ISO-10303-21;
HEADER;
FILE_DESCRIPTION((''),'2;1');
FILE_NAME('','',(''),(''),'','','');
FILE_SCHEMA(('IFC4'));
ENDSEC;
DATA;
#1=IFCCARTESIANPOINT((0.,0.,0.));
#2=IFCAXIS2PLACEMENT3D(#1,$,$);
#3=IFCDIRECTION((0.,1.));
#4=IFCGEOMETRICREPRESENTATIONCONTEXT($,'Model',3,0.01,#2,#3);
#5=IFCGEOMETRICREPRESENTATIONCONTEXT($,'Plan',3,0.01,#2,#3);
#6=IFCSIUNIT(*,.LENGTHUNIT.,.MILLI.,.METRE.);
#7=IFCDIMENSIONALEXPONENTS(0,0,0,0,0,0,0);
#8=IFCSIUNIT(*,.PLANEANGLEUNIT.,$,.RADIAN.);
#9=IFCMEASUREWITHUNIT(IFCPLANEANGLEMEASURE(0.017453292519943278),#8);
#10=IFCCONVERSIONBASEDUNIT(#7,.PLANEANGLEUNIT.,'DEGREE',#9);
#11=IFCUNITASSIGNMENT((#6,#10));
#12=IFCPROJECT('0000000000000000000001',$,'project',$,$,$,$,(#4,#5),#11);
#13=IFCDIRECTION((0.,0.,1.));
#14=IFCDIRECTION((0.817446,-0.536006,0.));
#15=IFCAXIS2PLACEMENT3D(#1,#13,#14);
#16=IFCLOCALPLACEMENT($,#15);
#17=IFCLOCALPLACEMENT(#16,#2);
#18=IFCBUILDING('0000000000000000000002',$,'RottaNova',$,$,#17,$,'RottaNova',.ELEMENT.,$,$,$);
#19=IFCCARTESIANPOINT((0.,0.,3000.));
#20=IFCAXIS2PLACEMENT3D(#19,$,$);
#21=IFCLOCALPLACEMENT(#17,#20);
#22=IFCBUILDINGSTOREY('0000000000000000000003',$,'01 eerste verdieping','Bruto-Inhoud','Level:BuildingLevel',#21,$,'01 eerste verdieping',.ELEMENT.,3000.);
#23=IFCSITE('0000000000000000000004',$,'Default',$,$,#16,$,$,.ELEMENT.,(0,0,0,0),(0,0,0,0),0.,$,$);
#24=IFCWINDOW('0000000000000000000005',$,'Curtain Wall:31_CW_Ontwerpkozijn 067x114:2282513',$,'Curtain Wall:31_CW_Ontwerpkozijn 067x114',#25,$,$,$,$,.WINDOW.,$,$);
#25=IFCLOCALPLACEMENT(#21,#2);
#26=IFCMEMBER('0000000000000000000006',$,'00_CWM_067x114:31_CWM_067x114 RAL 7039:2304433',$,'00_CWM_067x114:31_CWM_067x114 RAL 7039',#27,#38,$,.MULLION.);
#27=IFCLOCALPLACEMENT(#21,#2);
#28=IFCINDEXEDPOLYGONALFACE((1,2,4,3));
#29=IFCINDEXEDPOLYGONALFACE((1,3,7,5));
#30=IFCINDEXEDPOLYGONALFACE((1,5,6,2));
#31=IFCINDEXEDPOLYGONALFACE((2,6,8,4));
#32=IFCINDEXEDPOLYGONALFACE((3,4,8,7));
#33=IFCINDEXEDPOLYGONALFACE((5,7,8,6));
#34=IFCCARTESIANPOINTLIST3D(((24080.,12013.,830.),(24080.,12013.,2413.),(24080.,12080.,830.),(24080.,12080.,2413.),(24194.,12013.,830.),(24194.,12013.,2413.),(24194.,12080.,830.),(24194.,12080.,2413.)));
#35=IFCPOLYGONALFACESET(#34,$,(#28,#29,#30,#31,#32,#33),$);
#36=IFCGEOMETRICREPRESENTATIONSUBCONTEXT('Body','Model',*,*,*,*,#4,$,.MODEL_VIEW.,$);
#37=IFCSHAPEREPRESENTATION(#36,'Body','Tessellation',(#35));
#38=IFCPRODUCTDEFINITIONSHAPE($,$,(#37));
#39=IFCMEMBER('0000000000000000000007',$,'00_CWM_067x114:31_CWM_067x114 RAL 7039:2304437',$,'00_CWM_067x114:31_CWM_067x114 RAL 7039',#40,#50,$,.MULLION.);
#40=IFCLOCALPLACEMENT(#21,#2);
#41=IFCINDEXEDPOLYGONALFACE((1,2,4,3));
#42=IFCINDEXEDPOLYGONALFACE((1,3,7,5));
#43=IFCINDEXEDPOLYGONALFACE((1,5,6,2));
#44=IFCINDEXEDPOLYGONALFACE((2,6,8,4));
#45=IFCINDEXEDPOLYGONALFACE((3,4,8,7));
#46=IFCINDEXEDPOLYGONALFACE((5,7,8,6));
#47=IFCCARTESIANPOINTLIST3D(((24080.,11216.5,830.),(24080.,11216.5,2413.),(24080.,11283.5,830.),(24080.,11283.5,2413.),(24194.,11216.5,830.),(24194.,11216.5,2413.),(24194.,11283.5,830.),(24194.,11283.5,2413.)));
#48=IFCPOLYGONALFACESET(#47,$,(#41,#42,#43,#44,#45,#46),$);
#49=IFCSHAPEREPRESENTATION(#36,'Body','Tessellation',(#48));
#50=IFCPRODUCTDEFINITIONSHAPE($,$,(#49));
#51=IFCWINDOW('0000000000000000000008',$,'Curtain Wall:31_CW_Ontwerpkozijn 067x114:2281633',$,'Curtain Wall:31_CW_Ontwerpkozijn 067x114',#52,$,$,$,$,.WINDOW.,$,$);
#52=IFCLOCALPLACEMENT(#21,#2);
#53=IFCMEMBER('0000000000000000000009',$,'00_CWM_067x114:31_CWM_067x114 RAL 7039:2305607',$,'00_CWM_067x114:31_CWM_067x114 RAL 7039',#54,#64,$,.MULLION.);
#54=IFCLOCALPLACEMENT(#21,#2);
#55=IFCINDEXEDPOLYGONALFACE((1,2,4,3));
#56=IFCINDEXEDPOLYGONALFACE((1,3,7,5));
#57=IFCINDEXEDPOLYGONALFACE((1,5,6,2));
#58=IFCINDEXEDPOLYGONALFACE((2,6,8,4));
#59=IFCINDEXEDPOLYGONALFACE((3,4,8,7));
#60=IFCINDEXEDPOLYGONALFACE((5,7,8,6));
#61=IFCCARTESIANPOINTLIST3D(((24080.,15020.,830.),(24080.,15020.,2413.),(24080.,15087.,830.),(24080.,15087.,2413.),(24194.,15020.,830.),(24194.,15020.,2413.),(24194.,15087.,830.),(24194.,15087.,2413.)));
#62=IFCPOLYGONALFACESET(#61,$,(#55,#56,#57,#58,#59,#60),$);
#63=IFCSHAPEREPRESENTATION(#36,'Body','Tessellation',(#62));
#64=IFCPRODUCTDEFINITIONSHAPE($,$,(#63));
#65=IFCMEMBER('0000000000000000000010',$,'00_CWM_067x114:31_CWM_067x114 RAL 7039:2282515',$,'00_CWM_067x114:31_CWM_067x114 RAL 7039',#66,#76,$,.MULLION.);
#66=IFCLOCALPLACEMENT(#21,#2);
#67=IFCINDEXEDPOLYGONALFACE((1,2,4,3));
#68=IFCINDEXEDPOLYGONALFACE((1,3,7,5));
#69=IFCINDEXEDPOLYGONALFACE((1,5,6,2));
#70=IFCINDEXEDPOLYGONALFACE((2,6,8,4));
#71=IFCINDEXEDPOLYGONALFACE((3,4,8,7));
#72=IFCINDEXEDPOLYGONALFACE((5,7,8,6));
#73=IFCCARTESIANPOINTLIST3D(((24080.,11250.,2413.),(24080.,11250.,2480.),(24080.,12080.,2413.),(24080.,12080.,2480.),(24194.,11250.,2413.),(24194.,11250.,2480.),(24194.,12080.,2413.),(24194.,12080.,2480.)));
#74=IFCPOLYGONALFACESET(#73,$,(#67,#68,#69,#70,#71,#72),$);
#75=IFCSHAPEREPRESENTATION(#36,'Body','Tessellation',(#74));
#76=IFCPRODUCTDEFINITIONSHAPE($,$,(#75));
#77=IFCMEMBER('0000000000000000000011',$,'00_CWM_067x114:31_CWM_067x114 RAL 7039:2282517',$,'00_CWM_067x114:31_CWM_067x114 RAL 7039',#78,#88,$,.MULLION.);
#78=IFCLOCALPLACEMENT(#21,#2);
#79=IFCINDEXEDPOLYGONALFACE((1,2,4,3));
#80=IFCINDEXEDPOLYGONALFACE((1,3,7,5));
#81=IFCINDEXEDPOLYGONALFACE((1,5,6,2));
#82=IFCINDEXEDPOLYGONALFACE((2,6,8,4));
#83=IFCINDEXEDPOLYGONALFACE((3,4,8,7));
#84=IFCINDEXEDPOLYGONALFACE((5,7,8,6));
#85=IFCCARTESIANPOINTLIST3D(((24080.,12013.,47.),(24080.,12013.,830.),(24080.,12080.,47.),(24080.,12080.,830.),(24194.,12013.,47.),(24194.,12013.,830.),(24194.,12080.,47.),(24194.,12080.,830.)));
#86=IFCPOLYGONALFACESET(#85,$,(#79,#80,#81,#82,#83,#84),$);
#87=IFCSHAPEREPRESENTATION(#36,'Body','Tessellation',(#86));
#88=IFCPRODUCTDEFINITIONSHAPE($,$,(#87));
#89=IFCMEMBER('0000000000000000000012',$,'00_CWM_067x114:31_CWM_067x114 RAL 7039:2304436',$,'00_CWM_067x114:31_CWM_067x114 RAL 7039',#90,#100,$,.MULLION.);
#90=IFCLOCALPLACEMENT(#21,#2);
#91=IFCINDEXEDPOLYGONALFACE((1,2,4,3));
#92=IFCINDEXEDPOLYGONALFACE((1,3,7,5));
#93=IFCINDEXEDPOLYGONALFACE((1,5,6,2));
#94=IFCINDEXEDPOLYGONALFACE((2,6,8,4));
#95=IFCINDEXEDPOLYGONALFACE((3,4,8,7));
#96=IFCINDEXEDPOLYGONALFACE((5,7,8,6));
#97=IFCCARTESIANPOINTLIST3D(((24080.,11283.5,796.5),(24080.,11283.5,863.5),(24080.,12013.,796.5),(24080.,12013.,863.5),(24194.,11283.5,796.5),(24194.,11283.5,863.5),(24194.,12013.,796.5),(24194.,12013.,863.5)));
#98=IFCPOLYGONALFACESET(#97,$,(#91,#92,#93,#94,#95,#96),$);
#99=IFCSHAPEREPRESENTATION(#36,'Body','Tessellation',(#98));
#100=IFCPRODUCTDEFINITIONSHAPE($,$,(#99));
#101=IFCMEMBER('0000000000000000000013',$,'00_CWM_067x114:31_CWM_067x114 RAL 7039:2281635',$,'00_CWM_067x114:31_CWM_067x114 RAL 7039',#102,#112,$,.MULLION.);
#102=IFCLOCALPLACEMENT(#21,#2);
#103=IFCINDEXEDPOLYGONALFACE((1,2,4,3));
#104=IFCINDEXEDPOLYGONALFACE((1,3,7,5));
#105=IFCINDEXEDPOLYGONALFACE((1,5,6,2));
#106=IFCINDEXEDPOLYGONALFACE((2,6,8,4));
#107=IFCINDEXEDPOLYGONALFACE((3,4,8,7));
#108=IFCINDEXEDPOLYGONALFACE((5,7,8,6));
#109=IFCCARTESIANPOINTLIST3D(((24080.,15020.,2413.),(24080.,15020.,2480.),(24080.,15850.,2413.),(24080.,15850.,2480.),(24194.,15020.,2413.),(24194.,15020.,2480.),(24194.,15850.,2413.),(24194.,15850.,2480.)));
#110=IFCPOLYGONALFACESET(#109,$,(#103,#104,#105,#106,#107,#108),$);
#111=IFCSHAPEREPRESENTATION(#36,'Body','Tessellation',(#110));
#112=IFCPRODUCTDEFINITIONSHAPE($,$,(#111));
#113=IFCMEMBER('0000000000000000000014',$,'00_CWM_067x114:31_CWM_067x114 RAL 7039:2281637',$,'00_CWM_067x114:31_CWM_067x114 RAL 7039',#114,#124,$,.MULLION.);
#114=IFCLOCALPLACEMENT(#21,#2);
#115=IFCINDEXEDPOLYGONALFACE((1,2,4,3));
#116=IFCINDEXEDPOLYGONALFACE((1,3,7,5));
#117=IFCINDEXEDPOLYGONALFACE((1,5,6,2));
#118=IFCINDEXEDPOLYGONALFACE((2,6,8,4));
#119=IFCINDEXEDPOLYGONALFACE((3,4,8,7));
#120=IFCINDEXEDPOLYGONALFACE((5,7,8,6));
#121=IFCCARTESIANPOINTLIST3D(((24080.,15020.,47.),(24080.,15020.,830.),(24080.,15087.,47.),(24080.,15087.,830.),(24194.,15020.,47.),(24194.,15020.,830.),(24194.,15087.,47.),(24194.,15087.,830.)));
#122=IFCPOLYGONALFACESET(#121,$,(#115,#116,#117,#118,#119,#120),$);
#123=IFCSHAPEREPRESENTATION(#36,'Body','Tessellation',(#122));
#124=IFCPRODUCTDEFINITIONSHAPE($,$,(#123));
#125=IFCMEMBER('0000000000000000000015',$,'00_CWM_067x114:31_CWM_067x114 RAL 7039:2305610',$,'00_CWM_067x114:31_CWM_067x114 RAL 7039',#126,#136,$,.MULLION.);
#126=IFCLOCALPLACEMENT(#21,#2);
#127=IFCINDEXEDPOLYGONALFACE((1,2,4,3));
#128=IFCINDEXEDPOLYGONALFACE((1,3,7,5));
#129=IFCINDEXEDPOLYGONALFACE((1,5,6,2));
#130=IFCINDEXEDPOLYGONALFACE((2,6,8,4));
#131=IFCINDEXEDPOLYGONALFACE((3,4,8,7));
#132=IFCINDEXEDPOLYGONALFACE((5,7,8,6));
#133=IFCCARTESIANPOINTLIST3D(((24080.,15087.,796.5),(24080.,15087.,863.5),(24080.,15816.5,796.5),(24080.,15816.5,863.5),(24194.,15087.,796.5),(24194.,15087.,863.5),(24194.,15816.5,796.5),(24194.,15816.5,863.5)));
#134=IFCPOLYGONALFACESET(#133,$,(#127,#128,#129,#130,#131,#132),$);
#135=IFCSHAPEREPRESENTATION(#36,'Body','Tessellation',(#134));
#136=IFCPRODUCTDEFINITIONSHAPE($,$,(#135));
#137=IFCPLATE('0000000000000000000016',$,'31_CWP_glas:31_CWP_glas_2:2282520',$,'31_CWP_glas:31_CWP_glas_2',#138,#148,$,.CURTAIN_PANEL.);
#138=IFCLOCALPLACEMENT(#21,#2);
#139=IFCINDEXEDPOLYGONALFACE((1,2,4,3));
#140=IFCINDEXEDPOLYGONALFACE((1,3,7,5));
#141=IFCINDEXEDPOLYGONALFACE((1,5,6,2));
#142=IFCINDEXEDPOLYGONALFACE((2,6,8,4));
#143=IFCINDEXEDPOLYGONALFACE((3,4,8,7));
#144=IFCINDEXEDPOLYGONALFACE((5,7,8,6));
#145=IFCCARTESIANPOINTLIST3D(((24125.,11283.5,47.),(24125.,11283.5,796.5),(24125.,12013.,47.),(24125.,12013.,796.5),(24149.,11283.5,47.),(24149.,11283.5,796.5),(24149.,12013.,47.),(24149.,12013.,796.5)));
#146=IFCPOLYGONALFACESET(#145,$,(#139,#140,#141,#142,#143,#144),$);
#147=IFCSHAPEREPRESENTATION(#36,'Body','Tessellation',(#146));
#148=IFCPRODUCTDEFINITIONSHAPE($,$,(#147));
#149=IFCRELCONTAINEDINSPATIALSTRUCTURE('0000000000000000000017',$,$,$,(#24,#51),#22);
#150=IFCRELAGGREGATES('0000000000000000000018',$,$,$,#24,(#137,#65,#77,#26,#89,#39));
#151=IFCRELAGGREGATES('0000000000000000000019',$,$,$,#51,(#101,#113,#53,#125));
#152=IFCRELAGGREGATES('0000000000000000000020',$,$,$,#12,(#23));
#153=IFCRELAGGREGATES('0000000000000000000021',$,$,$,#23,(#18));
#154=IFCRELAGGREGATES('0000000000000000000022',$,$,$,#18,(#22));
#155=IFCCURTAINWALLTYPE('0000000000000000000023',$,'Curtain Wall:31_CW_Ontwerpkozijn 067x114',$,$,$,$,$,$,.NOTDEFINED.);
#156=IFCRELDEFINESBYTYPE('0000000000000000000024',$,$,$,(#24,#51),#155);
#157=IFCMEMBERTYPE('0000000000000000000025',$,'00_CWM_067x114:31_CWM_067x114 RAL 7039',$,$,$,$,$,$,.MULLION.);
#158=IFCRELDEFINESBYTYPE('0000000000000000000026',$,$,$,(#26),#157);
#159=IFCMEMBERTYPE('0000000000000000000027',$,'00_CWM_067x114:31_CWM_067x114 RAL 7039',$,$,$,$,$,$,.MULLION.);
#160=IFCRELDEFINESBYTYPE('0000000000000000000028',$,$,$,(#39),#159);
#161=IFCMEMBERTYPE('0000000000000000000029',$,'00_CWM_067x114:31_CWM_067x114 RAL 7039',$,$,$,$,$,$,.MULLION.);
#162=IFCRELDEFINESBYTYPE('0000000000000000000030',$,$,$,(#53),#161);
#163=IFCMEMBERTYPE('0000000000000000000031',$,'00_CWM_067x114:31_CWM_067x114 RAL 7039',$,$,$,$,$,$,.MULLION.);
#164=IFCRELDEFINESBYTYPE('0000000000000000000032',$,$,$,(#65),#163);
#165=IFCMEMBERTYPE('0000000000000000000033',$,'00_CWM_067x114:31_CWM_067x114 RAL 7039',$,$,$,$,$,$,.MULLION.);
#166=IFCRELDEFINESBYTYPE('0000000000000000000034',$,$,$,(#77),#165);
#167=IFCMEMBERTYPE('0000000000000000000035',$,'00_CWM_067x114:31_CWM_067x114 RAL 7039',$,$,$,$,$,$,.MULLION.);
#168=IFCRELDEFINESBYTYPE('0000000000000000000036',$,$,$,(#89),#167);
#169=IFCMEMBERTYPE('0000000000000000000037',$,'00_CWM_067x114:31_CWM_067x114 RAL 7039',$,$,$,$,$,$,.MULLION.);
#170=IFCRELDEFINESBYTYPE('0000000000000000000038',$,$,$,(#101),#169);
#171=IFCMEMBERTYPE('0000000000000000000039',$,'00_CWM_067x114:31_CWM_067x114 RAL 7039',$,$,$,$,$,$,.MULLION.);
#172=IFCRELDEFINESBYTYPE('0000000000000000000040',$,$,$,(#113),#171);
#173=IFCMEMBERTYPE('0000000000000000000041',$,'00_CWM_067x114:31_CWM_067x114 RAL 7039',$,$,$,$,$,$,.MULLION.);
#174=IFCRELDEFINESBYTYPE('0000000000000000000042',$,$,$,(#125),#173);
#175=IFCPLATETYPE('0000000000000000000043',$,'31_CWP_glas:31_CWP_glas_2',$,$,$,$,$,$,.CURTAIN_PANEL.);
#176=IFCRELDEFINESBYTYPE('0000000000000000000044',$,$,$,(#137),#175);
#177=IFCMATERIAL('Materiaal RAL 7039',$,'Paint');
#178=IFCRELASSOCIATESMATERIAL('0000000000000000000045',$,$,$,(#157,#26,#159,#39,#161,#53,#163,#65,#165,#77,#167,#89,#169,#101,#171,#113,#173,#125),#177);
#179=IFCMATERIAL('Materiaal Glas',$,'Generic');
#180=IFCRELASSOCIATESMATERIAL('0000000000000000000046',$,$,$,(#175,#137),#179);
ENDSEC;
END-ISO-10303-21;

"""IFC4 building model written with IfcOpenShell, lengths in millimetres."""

from ifc_helpers import new_model, entity, si_unit, converted_unit, direction, frame, origin, place, context, subcontext, project, spatial, indexed_curve, outline, extrude, source, transform, mapped, material, type_object, type_shapes, element, aggregate, save


model = new_model("IFC4")

# Units and contexts
model_context = context("Model", 3, precision=0.01, world=origin(), true_north=direction((0.0, 1.0)))
plan_context = context("Plan", 3, precision=0.01, world=origin(), true_north=direction((0.0, 1.0)))
body_context = subcontext(model_context, "Body", "Model", "MODEL_VIEW")
ifc_project = project(units=[si_unit("LENGTHUNIT", "METRE", prefix="MILLI"), converted_unit("PLANEANGLEUNIT", "DEGREE", entity("IfcPlaneAngleMeasure", 0.017453292519943278), si_unit("PLANEANGLEUNIT", "RADIAN"), dimensions=[0, 0, 0, 0, 0, 0, 0])], contexts=[model_context, plan_context])

# Site, building, storey
site_placement = place(None, frame((0.0, 0.0, 0.0), z_axis=(0.0, 0.0, 1.0), x_axis=(0.817446, -0.536006, 0.0)))
site = spatial("IfcSite", under=ifc_project, at=site_placement, Name="Default", CompositionType="ELEMENT", RefLatitude=(0, 0, 0, 0), RefLongitude=(0, 0, 0, 0), RefElevation=0.0)
building_placement = place(site_placement, origin())
building = spatial("IfcBuilding", under=site, at=building_placement, Name="RottaNova", LongName="RottaNova", CompositionType="ELEMENT")
storey_placement = place(building_placement, frame((0.0, 0.0, 3000.0)))
storey = spatial("IfcBuildingStorey", under=building, at=storey_placement, Name="01 eerste verdieping", Description="Bruto-Inhoud", ObjectType="Level:BuildingLevel", LongName="01 eerste verdieping", CompositionType="ELEMENT", Elevation=3000.0)

# Window, members
curtain_wall_type = type_object("IfcCurtainWallType", Name="Curtain Wall:31_CW_Ontwerpkozijn 067x114", PredefinedType="NOTDEFINED")
window_1_placement = place(storey_placement, frame((0.0, 0.0, -3000.0)))
window_1 = element("IfcWindow", 1, at=window_1_placement, inside=storey, type_object=curtain_wall_type, Name="Curtain Wall:31_CW_Ontwerpkozijn 067x114:2282513", ObjectType="Curtain Wall:31_CW_Ontwerpkozijn 067x114", PredefinedType="WINDOW")
ifc_material_1 = material(Name="Materiaal RAL 7039", Category="Paint")
member_type_1 = type_object("IfcMemberType", Name="00_CWM_067x114:31_CWM_067x114 RAL 7039", PredefinedType="MULLION", material=ifc_material_1)
shared_shape_1 = source(origin(), body_context, "Body", "SweptSolid", [
    extrude(outline(indexed_curve([(-33.5, -57.0), (33.5, -57.0), (33.5, 57.0), (-33.5, 57.0), (-33.5, -57.0)], self_intersect=False)), frame((-33.5, 57.0, -1583.0), z_axis=(0.0, 0.0, 1.0), x_axis=(-1.0, 0.0, 0.0)), (0.0, 0.0, 1.0), 1583.0),
])
type_shapes(member_type_1, [shared_shape_1])
member_1_placement = place(window_1_placement, frame((24080.0, 12080.0, 3830.0), z_axis=(0.0, 0.0, -1.0), x_axis=(0.0, 1.0, 0.0)))
member_1 = element("IfcMember", 2, at=member_1_placement, type_object=member_type_1, material=ifc_material_1, Name="00_CWM_067x114:31_CWM_067x114 RAL 7039:2304433", ObjectType="00_CWM_067x114:31_CWM_067x114 RAL 7039", PredefinedType="MULLION", context=body_context, shape_type="MappedRepresentation", body=[
    mapped(shared_shape_1, transform((0.0, 0.0, 0.0), scale=1.0)),
])
member_type_2 = type_object("IfcMemberType", Name="00_CWM_067x114:31_CWM_067x114 RAL 7039", PredefinedType="MULLION", material=ifc_material_1)
shared_shape_2 = source(origin(), body_context, "Body", "SweptSolid", [
    extrude(outline(indexed_curve([(-33.5, -57.0), (33.5, -57.0), (33.5, 57.0), (-33.5, 57.0), (-33.5, -57.0)], self_intersect=False)), frame((0.0, 57.0, -1583.0), z_axis=(0.0, 0.0, 1.0), x_axis=(-1.0, 0.0, 0.0)), (0.0, 0.0, 1.0), 1583.0),
])
type_shapes(member_type_2, [shared_shape_2])
member_2_placement = place(window_1_placement, frame((24080.0, 11250.0, 3830.0), z_axis=(0.0, 0.0, -1.0), x_axis=(0.0, 1.0, 0.0)))
member_2 = element("IfcMember", 3, at=member_2_placement, type_object=member_type_2, material=ifc_material_1, Name="00_CWM_067x114:31_CWM_067x114 RAL 7039:2304437", ObjectType="00_CWM_067x114:31_CWM_067x114 RAL 7039", PredefinedType="MULLION", context=body_context, shape_type="MappedRepresentation", body=[
    mapped(shared_shape_2, transform((0.0, 0.0, 0.0), scale=1.0)),
])

# Window, member
window_2_placement = place(storey_placement, frame((0.0, 0.0, -3000.0)))
window_2 = element("IfcWindow", 4, at=window_2_placement, inside=storey, type_object=curtain_wall_type, Name="Curtain Wall:31_CW_Ontwerpkozijn 067x114:2281633", ObjectType="Curtain Wall:31_CW_Ontwerpkozijn 067x114", PredefinedType="WINDOW")
member_type_3 = type_object("IfcMemberType", Name="00_CWM_067x114:31_CWM_067x114 RAL 7039", PredefinedType="MULLION", material=ifc_material_1)
shared_shape_3 = source(origin(), body_context, "Body", "SweptSolid", [
    extrude(outline(indexed_curve([(-33.5, -57.0), (33.5, -57.0), (33.5, 57.0), (-33.5, 57.0), (-33.5, -57.0)], self_intersect=False)), frame((-33.5, -57.0, -1583.0), z_axis=(0.0, 0.0, 1.0), x_axis=(-1.0, 0.0, 0.0)), (0.0, 0.0, 1.0), 1583.0),
])
type_shapes(member_type_3, [shared_shape_3])
member_3_placement = place(window_2_placement, frame((24080.0, 15020.0, 3830.0), z_axis=(0.0, 0.0, -1.0), x_axis=(0.0, -1.0, 0.0)))
member_3 = element("IfcMember", 5, at=member_3_placement, type_object=member_type_3, material=ifc_material_1, Name="00_CWM_067x114:31_CWM_067x114 RAL 7039:2305607", ObjectType="00_CWM_067x114:31_CWM_067x114 RAL 7039", PredefinedType="MULLION", context=body_context, shape_type="MappedRepresentation", body=[
    mapped(shared_shape_3, transform((0.0, 0.0, 0.0), scale=1.0)),
])

# Members
member_type_4 = type_object("IfcMemberType", Name="00_CWM_067x114:31_CWM_067x114 RAL 7039", PredefinedType="MULLION", material=ifc_material_1)
shared_shape_4 = source(origin(), body_context, "Body", "SweptSolid", [
    extrude(outline(indexed_curve([(-33.5, -57.0), (33.5, -57.0), (33.5, 57.0), (-33.5, 57.0), (-33.5, -57.0)], self_intersect=False)), frame((-33.5, 57.0, -830.0), z_axis=(0.0, 0.0, 1.0), x_axis=(-1.0, 0.0, 0.0)), (0.0, 0.0, 1.0), 830.0),
])
type_shapes(member_type_4, [shared_shape_4])
member_4_placement = place(window_1_placement, frame((24080.0, 12080.0, 5480.0), z_axis=(0.0, 1.0, 0.0), x_axis=(0.0, 0.0, 1.0)))
member_4 = element("IfcMember", 6, at=member_4_placement, type_object=member_type_4, material=ifc_material_1, Name="00_CWM_067x114:31_CWM_067x114 RAL 7039:2282515", ObjectType="00_CWM_067x114:31_CWM_067x114 RAL 7039", PredefinedType="MULLION", context=body_context, shape_type="MappedRepresentation", body=[
    mapped(shared_shape_4, transform((0.0, 0.0, 0.0), scale=1.0)),
])
member_type_5 = type_object("IfcMemberType", Name="00_CWM_067x114:31_CWM_067x114 RAL 7039", PredefinedType="MULLION", material=ifc_material_1)
shared_shape_5 = source(origin(), body_context, "Body", "SweptSolid", [
    extrude(outline(indexed_curve([(-33.5, -57.0), (33.5, -57.0), (33.5, 57.0), (-33.5, 57.0), (-33.5, -57.0)], self_intersect=False)), frame((-33.5, 57.0, -783.0), z_axis=(0.0, 0.0, 1.0), x_axis=(-1.0, 0.0, 0.0)), (0.0, 0.0, 1.0), 783.0),
])
type_shapes(member_type_5, [shared_shape_5])
member_5_placement = place(window_1_placement, frame((24080.0, 12080.0, 3047.0), z_axis=(0.0, 0.0, -1.0), x_axis=(0.0, 1.0, 0.0)))
member_5 = element("IfcMember", 7, at=member_5_placement, type_object=member_type_5, material=ifc_material_1, Name="00_CWM_067x114:31_CWM_067x114 RAL 7039:2282517", ObjectType="00_CWM_067x114:31_CWM_067x114 RAL 7039", PredefinedType="MULLION", context=body_context, shape_type="MappedRepresentation", body=[
    mapped(shared_shape_5, transform((0.0, 0.0, 0.0), scale=1.0)),
])
member_type_6 = type_object("IfcMemberType", Name="00_CWM_067x114:31_CWM_067x114 RAL 7039", PredefinedType="MULLION", material=ifc_material_1)
shared_shape_6 = source(origin(), body_context, "Body", "SweptSolid", [
    extrude(outline(indexed_curve([(-33.5, -57.0), (33.5, -57.0), (33.5, 57.0), (-33.5, 57.0), (-33.5, -57.0)], self_intersect=False)), frame((0.0, 57.0, -729.5), z_axis=(0.0, 0.0, 1.0), x_axis=(-1.0, 0.0, 0.0)), (0.0, 0.0, 1.0), 729.5),
])
type_shapes(member_type_6, [shared_shape_6])
member_6_placement = place(window_1_placement, frame((24080.0, 12013.0, 3830.0), z_axis=(0.0, 1.0, 0.0), x_axis=(0.0, 0.0, 1.0)))
member_6 = element("IfcMember", 8, at=member_6_placement, type_object=member_type_6, material=ifc_material_1, Name="00_CWM_067x114:31_CWM_067x114 RAL 7039:2304436", ObjectType="00_CWM_067x114:31_CWM_067x114 RAL 7039", PredefinedType="MULLION", context=body_context, shape_type="MappedRepresentation", body=[
    mapped(shared_shape_6, transform((0.0, 0.0, 0.0), scale=1.0)),
])
member_type_7 = type_object("IfcMemberType", Name="00_CWM_067x114:31_CWM_067x114 RAL 7039", PredefinedType="MULLION", material=ifc_material_1)
shared_shape_7 = source(origin(), body_context, "Body", "SweptSolid", [
    extrude(outline(indexed_curve([(-33.5, -57.0), (33.5, -57.0), (33.5, 57.0), (-33.5, 57.0), (-33.5, -57.0)], self_intersect=False)), frame((-33.5, -57.0, -830.0), z_axis=(0.0, 0.0, 1.0), x_axis=(-1.0, 0.0, 0.0)), (0.0, 0.0, 1.0), 830.0),
])
type_shapes(member_type_7, [shared_shape_7])
member_7_placement = place(window_2_placement, frame((24080.0, 15020.0, 5480.0), z_axis=(0.0, -1.0, 0.0), x_axis=(0.0, 0.0, 1.0)))
member_7 = element("IfcMember", 9, at=member_7_placement, type_object=member_type_7, material=ifc_material_1, Name="00_CWM_067x114:31_CWM_067x114 RAL 7039:2281635", ObjectType="00_CWM_067x114:31_CWM_067x114 RAL 7039", PredefinedType="MULLION", context=body_context, shape_type="MappedRepresentation", body=[
    mapped(shared_shape_7, transform((0.0, 0.0, 0.0), scale=1.0)),
])
member_type_8 = type_object("IfcMemberType", Name="00_CWM_067x114:31_CWM_067x114 RAL 7039", PredefinedType="MULLION", material=ifc_material_1)
shared_shape_8 = source(origin(), body_context, "Body", "SweptSolid", [
    extrude(outline(indexed_curve([(-33.5, -57.0), (33.5, -57.0), (33.5, 57.0), (-33.5, 57.0), (-33.5, -57.0)], self_intersect=False)), frame((-33.5, -57.0, -783.0), z_axis=(0.0, 0.0, 1.0), x_axis=(-1.0, 0.0, 0.0)), (0.0, 0.0, 1.0), 783.0),
])
type_shapes(member_type_8, [shared_shape_8])
member_8_placement = place(window_2_placement, frame((24080.0, 15020.0, 3047.0), z_axis=(0.0, 0.0, -1.0), x_axis=(0.0, -1.0, 0.0)))
member_8 = element("IfcMember", 10, at=member_8_placement, type_object=member_type_8, material=ifc_material_1, Name="00_CWM_067x114:31_CWM_067x114 RAL 7039:2281637", ObjectType="00_CWM_067x114:31_CWM_067x114 RAL 7039", PredefinedType="MULLION", context=body_context, shape_type="MappedRepresentation", body=[
    mapped(shared_shape_8, transform((0.0, 0.0, 0.0), scale=1.0)),
])
member_type_9 = type_object("IfcMemberType", Name="00_CWM_067x114:31_CWM_067x114 RAL 7039", PredefinedType="MULLION", material=ifc_material_1)
shared_shape_9 = source(origin(), body_context, "Body", "SweptSolid", [
    extrude(outline(indexed_curve([(-33.5, -57.0), (33.5, -57.0), (33.5, 57.0), (-33.5, 57.0), (-33.5, -57.0)], self_intersect=False)), frame((0.0, -57.0, -729.5), z_axis=(0.0, 0.0, 1.0), x_axis=(-1.0, 0.0, 0.0)), (0.0, 0.0, 1.0), 729.5),
])
type_shapes(member_type_9, [shared_shape_9])
member_9_placement = place(window_2_placement, frame((24080.0, 15087.0, 3830.0), z_axis=(0.0, -1.0, 0.0), x_axis=(0.0, 0.0, 1.0)))
member_9 = element("IfcMember", 11, at=member_9_placement, type_object=member_type_9, material=ifc_material_1, Name="00_CWM_067x114:31_CWM_067x114 RAL 7039:2305610", ObjectType="00_CWM_067x114:31_CWM_067x114 RAL 7039", PredefinedType="MULLION", context=body_context, shape_type="MappedRepresentation", body=[
    mapped(shared_shape_9, transform((0.0, 0.0, 0.0), scale=1.0)),
])

# Plate
ifc_material_2 = material(Name="Materiaal Glas", Category="Generic")
plate_type_1 = type_object("IfcPlateType", Name="31_CWP_glas:31_CWP_glas_2", PredefinedType="CURTAIN_PANEL", material=ifc_material_2)
shared_shape_10 = source(origin(), body_context, "Body", "SweptSolid", [
    extrude(outline(indexed_curve([(-12.0, -364.7), (12.0, -364.7), (12.0, 364.7), (-12.0, 364.7), (-12.0, -364.7)], self_intersect=False)), frame((0.0, -57.0, 0.0), z_axis=(0.0, 0.0, 1.0), x_axis=(0.0, 1.0, 0.0)), (0.0, 0.0, 1.0), 749.5),
])
type_shapes(plate_type_1, [shared_shape_10])
plate_1_placement = place(window_1_placement, frame((24080.0, 11648.2, 3047.0), z_axis=(0.0, 0.0, 1.0), x_axis=(0.0, 1.0, 0.0)))
plate_1 = element("IfcPlate", 12, at=plate_1_placement, type_object=plate_type_1, material=ifc_material_2, Name="31_CWP_glas:31_CWP_glas_2:2282520", ObjectType="31_CWP_glas:31_CWP_glas_2", PredefinedType="CURTAIN_PANEL", context=body_context, shape_type="MappedRepresentation", body=[
    mapped(shared_shape_10, transform((0.0, 0.0, 0.0), scale=1.0)),
])
aggregate(window_1, [plate_1, member_4, member_5, member_1, member_6, member_2])
aggregate(window_2, [member_7, member_8, member_3, member_9])

save(model, "model.ifc")
